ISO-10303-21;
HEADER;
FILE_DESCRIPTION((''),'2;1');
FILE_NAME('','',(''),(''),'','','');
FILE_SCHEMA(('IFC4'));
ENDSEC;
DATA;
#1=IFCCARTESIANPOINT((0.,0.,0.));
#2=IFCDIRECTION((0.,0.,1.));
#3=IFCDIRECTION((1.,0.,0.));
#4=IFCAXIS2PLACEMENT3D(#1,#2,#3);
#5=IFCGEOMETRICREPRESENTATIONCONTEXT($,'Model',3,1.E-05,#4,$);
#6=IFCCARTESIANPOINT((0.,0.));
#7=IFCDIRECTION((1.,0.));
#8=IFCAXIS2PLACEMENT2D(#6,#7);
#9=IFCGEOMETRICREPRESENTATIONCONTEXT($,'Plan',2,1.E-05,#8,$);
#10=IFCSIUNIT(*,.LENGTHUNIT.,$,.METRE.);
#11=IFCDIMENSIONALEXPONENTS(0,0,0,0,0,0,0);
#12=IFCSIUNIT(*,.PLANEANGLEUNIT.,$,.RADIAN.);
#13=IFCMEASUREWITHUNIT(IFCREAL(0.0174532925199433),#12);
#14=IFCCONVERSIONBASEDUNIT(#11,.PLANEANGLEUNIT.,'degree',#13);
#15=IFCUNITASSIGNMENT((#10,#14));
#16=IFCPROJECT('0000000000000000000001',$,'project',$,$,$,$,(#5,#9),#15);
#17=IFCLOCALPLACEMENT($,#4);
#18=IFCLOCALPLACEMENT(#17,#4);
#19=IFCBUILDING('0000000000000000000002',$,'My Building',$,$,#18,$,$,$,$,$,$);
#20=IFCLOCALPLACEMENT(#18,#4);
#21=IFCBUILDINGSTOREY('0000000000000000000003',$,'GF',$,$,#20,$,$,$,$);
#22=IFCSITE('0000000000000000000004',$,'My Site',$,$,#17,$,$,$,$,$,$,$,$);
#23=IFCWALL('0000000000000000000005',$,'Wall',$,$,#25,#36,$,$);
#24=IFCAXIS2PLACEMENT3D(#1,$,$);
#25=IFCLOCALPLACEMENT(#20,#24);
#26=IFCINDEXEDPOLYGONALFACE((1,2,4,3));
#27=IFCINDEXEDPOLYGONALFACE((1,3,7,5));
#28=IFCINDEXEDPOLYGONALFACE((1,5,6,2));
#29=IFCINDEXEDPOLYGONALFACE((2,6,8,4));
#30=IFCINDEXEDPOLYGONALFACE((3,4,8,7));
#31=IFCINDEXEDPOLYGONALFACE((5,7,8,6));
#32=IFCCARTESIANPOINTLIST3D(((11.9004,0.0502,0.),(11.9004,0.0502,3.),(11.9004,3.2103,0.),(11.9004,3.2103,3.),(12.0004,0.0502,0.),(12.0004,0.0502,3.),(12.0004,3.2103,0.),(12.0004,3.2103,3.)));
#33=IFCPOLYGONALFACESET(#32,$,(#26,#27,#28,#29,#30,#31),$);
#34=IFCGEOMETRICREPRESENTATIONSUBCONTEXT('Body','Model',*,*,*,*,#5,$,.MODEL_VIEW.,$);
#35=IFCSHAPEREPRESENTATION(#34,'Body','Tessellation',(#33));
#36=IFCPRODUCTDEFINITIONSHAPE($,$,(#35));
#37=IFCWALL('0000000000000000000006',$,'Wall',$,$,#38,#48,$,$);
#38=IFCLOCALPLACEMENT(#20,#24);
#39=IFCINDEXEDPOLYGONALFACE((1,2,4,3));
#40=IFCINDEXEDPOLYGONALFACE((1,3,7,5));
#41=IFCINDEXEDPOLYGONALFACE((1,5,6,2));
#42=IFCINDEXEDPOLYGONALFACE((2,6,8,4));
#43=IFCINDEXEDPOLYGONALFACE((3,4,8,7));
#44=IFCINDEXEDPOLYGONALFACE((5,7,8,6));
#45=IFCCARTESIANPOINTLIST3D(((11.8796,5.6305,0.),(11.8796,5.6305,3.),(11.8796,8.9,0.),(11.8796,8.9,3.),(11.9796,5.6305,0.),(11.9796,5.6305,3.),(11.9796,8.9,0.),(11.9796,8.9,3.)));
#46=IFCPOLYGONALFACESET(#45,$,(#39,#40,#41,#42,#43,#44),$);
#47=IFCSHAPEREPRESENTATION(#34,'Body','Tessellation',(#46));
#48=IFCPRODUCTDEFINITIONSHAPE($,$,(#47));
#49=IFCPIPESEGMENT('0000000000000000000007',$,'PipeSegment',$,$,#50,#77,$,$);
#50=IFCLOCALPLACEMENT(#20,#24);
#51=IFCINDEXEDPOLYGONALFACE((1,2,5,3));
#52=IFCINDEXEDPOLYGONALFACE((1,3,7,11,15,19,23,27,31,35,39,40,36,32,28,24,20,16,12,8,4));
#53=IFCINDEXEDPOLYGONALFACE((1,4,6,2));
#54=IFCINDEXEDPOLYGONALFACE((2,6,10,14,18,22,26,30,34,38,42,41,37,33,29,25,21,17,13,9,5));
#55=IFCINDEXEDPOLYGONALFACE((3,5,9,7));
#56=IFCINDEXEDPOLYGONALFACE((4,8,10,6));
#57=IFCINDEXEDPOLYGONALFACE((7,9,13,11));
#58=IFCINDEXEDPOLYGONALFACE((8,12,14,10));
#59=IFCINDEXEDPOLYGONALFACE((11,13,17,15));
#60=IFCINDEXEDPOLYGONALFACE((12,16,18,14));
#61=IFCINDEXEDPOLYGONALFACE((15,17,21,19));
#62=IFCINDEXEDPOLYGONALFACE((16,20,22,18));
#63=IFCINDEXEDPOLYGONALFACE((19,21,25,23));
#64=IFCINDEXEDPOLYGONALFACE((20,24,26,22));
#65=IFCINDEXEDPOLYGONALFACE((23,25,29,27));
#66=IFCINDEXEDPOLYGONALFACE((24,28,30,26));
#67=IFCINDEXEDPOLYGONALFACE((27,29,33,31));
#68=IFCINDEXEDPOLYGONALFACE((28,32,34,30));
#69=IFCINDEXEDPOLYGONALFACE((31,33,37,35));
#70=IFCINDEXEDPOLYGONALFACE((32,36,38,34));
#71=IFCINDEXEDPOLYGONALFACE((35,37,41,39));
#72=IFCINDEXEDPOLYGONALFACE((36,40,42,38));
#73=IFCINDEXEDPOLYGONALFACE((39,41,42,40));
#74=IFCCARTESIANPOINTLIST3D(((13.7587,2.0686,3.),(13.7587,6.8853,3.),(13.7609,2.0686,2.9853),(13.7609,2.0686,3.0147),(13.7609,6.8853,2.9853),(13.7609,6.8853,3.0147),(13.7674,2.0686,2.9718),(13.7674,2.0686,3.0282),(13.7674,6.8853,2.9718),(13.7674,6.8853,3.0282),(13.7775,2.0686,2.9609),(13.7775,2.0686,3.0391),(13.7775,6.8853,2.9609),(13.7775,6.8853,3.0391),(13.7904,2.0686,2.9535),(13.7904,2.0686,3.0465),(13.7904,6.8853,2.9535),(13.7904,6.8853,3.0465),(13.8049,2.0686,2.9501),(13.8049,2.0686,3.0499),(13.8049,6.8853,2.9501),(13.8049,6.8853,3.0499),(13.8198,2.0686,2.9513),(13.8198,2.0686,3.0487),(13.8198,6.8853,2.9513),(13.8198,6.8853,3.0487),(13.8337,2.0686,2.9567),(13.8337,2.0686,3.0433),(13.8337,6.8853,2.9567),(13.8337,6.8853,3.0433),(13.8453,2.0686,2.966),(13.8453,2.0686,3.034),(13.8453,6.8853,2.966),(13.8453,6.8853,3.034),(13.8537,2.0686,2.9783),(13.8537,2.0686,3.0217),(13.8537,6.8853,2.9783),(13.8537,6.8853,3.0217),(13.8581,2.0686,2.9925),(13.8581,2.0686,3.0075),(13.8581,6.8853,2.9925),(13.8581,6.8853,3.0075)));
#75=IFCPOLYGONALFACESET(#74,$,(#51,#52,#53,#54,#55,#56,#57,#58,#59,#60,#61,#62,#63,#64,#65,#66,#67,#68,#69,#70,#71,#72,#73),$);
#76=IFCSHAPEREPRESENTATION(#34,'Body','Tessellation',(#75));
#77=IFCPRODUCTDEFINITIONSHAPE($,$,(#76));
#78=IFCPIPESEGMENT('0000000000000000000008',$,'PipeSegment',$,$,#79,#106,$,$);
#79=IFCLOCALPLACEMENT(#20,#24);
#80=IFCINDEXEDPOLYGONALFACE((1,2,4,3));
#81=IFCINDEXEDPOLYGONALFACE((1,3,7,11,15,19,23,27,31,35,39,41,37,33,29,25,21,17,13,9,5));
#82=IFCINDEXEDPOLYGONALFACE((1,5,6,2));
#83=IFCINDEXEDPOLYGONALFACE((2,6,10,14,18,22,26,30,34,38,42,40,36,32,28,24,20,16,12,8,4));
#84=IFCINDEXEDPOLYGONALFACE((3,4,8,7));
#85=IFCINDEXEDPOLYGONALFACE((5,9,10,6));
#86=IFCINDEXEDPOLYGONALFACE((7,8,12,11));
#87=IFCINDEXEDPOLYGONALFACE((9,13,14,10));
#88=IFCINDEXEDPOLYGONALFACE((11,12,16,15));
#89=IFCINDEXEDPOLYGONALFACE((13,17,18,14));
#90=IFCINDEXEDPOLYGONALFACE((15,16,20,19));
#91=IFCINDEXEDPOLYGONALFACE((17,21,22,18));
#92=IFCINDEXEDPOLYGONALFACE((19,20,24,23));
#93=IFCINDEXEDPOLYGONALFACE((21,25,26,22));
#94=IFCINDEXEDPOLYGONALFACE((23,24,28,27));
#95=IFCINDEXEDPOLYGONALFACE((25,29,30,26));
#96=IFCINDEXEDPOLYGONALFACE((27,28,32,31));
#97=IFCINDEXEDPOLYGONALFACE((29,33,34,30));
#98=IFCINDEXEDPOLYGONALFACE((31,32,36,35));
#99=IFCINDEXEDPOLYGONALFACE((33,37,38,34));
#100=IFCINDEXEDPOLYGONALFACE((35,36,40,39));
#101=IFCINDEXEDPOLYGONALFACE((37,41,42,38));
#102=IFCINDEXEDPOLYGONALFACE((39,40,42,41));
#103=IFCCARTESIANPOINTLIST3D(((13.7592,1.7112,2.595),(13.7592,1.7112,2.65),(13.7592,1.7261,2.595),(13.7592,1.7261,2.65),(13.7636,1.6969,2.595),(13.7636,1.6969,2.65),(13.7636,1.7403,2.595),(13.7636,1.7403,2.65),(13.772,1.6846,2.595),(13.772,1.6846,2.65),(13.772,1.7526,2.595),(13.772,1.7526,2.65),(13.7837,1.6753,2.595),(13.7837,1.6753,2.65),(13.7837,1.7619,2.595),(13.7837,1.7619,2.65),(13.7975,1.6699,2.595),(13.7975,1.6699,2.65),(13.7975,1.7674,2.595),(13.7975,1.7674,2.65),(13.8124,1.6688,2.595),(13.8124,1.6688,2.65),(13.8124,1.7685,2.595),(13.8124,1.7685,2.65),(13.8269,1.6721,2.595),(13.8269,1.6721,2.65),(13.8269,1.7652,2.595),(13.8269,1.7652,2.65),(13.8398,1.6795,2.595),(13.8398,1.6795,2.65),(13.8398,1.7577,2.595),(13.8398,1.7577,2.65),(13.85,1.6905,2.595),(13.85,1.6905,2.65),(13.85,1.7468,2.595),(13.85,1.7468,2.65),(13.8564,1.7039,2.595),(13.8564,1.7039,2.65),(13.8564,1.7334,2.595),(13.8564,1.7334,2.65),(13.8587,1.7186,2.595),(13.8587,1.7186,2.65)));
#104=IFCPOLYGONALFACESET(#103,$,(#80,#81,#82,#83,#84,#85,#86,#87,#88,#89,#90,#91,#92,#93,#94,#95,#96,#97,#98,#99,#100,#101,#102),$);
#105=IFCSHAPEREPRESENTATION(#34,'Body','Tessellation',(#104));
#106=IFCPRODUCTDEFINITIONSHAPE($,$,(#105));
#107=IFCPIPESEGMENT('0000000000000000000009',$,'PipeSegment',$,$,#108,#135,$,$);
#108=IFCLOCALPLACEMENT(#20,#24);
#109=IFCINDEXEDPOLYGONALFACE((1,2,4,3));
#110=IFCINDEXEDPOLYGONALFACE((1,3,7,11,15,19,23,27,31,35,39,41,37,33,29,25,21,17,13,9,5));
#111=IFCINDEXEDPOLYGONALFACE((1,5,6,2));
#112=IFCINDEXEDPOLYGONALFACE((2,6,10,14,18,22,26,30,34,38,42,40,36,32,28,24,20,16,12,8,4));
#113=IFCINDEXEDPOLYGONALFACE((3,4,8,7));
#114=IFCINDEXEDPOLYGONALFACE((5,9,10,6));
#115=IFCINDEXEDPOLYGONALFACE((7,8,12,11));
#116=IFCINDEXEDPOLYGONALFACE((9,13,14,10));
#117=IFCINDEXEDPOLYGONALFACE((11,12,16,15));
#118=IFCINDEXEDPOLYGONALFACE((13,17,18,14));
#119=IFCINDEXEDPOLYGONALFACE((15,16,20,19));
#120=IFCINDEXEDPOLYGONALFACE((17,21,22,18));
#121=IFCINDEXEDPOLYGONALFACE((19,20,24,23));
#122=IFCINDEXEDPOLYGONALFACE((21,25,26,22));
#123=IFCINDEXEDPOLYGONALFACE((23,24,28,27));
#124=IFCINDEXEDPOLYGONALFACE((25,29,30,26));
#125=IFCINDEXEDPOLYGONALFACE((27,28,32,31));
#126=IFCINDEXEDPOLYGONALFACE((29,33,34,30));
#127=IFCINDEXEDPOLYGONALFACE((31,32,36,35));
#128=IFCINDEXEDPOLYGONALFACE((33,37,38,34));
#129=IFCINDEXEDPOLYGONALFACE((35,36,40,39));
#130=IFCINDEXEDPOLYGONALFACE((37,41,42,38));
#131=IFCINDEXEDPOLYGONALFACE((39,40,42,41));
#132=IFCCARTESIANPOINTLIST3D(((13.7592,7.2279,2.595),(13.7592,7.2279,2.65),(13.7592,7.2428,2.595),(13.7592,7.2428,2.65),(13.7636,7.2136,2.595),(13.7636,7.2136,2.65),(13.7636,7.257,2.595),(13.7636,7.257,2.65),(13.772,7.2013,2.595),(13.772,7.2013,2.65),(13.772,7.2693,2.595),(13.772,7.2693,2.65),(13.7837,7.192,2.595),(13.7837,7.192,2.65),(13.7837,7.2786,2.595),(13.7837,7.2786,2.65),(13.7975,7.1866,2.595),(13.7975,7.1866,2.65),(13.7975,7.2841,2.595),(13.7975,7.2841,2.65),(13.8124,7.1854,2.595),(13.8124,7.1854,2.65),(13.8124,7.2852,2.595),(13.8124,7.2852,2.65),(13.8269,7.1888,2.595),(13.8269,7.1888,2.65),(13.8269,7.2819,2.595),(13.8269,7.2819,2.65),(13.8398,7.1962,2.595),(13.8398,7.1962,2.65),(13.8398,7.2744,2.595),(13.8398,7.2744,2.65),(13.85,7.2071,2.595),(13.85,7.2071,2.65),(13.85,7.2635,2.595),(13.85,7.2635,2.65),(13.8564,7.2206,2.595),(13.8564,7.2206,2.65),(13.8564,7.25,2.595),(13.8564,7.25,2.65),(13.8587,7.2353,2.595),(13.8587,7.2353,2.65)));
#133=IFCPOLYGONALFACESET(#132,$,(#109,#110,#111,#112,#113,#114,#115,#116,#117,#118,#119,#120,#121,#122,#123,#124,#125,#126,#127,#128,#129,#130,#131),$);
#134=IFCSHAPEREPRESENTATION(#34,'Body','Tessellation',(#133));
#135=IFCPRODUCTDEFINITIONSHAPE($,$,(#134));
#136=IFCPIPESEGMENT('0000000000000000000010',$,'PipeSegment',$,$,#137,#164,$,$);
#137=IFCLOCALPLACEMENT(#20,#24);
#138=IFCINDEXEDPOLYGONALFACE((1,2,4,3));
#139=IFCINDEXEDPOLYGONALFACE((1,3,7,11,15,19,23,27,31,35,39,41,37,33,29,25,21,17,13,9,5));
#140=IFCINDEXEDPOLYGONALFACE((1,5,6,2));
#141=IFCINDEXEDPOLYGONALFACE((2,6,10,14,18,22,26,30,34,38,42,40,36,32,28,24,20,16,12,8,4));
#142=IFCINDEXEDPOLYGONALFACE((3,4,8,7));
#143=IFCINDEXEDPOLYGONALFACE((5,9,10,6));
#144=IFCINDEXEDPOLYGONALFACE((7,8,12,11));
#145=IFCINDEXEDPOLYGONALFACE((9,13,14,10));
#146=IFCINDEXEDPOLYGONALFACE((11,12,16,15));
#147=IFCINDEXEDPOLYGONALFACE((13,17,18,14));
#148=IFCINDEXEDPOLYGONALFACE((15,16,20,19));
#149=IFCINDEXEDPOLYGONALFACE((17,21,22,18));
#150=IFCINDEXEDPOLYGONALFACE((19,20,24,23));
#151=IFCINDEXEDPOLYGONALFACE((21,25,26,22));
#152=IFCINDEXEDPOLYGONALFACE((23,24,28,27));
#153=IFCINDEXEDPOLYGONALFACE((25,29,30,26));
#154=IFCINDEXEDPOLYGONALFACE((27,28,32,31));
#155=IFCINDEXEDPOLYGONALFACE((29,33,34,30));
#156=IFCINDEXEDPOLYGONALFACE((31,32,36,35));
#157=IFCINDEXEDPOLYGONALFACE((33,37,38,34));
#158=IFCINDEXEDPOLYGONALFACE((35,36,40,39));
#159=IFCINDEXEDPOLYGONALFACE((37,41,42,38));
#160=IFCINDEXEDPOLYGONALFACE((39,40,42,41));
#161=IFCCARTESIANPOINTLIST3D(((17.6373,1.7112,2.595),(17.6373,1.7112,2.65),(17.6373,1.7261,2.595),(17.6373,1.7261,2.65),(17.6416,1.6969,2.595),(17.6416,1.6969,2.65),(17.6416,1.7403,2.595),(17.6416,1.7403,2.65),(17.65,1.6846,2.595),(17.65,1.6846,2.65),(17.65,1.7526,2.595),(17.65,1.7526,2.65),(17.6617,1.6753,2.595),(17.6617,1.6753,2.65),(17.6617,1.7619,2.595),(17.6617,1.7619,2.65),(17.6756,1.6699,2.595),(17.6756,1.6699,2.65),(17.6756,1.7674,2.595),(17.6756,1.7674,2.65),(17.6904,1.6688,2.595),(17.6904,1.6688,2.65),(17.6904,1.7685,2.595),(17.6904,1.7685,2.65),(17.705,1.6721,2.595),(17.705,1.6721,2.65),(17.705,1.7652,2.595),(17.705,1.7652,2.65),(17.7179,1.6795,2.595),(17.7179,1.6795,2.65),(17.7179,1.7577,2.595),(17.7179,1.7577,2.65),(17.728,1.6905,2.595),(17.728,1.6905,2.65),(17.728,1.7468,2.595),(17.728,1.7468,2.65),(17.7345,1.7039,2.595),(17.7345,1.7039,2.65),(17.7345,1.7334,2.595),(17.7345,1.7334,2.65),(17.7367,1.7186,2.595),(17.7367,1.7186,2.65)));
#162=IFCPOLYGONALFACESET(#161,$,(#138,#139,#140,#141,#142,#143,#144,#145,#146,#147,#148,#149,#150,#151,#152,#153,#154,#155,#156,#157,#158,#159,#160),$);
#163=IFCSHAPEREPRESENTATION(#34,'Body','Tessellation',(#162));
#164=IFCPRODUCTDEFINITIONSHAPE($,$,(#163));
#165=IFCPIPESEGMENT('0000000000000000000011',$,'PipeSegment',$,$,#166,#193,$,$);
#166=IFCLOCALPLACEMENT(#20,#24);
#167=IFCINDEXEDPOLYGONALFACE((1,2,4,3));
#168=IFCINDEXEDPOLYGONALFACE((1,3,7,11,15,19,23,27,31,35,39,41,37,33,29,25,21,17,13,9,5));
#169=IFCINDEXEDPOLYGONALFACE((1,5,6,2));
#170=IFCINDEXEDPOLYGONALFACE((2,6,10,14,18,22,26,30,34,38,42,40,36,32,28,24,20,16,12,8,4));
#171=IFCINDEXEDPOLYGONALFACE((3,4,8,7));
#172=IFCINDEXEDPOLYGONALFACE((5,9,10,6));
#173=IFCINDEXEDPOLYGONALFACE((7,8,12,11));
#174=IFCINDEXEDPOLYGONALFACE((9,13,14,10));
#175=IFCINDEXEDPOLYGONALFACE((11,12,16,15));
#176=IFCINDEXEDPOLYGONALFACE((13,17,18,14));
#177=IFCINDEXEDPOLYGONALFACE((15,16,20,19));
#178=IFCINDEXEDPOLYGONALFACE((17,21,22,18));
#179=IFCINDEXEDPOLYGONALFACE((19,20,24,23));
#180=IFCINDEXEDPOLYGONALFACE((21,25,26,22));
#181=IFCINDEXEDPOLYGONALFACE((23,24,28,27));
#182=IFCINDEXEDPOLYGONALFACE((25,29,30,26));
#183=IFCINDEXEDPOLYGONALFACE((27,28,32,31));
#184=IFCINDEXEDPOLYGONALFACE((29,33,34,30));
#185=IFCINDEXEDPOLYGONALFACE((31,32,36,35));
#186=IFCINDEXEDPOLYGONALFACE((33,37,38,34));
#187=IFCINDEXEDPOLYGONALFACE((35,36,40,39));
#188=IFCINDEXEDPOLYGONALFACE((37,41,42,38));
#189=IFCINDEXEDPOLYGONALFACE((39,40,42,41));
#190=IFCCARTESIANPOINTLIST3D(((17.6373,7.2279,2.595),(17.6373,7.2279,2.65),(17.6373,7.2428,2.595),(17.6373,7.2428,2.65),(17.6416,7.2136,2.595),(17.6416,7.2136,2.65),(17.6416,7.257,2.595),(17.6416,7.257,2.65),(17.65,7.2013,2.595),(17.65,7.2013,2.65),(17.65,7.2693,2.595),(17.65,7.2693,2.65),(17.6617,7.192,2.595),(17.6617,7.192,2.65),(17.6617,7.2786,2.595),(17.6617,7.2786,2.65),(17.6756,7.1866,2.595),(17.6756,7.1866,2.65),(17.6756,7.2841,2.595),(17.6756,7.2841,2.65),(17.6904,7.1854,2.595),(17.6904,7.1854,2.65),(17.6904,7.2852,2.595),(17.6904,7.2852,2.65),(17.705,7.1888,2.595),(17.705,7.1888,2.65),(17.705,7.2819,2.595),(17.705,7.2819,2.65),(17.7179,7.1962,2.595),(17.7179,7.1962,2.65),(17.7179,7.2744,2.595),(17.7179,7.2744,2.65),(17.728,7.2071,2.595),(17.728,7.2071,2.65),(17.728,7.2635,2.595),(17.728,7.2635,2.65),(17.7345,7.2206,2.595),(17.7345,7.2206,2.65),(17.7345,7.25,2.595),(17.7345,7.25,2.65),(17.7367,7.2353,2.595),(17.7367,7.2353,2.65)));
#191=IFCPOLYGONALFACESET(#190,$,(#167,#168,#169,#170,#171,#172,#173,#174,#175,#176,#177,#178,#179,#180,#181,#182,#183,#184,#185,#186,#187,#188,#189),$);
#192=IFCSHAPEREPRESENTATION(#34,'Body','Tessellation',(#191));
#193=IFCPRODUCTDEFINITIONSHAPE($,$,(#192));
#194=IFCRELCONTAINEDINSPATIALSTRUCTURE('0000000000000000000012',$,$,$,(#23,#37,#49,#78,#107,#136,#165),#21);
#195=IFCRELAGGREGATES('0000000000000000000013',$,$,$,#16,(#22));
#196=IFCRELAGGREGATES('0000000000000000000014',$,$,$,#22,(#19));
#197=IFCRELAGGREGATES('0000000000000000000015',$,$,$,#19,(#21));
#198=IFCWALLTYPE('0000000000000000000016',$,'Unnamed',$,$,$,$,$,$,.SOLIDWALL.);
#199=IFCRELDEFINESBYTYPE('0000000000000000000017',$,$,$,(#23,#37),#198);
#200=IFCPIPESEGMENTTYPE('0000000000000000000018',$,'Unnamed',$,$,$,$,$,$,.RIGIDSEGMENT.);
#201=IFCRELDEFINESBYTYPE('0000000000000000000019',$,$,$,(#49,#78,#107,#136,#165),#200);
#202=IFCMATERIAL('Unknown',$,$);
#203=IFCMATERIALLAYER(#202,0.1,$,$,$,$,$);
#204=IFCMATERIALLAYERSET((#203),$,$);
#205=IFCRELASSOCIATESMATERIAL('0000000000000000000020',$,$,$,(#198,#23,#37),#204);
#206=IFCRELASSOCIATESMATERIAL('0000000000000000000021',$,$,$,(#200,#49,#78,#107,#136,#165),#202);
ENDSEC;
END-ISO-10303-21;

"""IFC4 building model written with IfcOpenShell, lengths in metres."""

from ifc_helpers import new_model, entity, si_unit, converted_unit, frame, origin_with_axes, origin_2d_with_axis, place, context, subcontext, project, spatial, line, indexed_curve, circle, outline, extrude, material, layer, layer_set, layer_usage, material_profile, profile_set, profile_usage, type_object, element, save


model = new_model("IFC4")

# Units and contexts
model_context = context("Model", 3, precision=1e-05, world=origin_with_axes())
plan_context = context("Plan", 2, precision=1e-05, world=origin_2d_with_axis())
body_context_1 = subcontext(model_context, "Body", "Model", "MODEL_VIEW")
ifc_project = project(units=[si_unit("LENGTHUNIT", "METRE"), converted_unit("PLANEANGLEUNIT", "degree", entity("IfcReal", 0.0174532925199433), si_unit("PLANEANGLEUNIT", "RADIAN"), dimensions=[0, 0, 0, 0, 0, 0, 0])], contexts=[model_context, plan_context])

# Site, building, storey
site_placement = place(None, origin_with_axes())
site = spatial("IfcSite", under=ifc_project, at=site_placement, Name="My Site")
building_placement = place(site_placement, origin_with_axes())
building = spatial("IfcBuilding", under=site, at=building_placement, Name="My Building")
storey_placement = place(building_placement, origin_with_axes())
storey = spatial("IfcBuildingStorey", under=building, at=storey_placement, Name="GF")

# Shared definitions
ifc_material = material(Name="Unknown")
ifc_layer = layer(ifc_material, 0.1)
ifc_layer_set = layer_set([ifc_layer])
wall_type = type_object("IfcWallType", Name="Unnamed", PredefinedType="SOLIDWALL", material=ifc_layer_set)

# Walls
ifc_layer_usage_1 = layer_usage(ifc_layer_set, "AXIS2", "POSITIVE", 0.0)
wall_1_placement = place(storey_placement, frame((12.0004, 0.0502, 0.0), z_axis=(0.0, 0.0, 1.0), x_axis=(0.000013, 1.0, 0.0)))
element("IfcWall", 1, at=wall_1_placement, inside=storey, type_object=wall_type, material=ifc_layer_usage_1, Name="Wall", context=body_context_1, shape_type="SweptSolid", body=[
    extrude(outline(indexed_curve([(0.0, 0.0), (0.0, 0.1), (3.1602, 0.1), (3.1602, 0.0)], segments=[line(1, 2, 3, 4, 1)])), origin_with_axes(), (0.0, 0.0, 1.0), 3.0),
])
ifc_layer_usage_2 = layer_usage(ifc_layer_set, "AXIS2", "POSITIVE", 0.0)
wall_2_placement = place(storey_placement, frame((11.9796, 5.6305, 0.0), z_axis=(0.0, 0.0, 1.0), x_axis=(0.0, 1.0, 0.0)))
element("IfcWall", 2, at=wall_2_placement, inside=storey, type_object=wall_type, material=ifc_layer_usage_2, Name="Wall", context=body_context_1, shape_type="SweptSolid", body=[
    extrude(outline(indexed_curve([(0.0, 0.0), (0.0, 0.1), (3.2695, 0.1), (3.2695, 0.0)], segments=[line(1, 2, 3, 4, 1)])), origin_with_axes(), (0.0, 0.0, 1.0), 3.0),
])

# Pipe segments
ifc_material_profile = material_profile(ifc_material, circle(Radius=0.05))
ifc_profile_set = profile_set([ifc_material_profile])
ifc_profile_usage_1 = profile_usage(ifc_profile_set, cardinal=5)
pipe_segment_type = type_object("IfcPipeSegmentType", Name="Unnamed", PredefinedType="RIGIDSEGMENT", material=ifc_profile_set)
pipe_segment_1_placement = place(storey_placement, frame((13.8087, 6.8853, 3.0), z_axis=(0.0, -1.0, 0.0), x_axis=(-1.0, 0.0, 0.0)))
element("IfcPipeSegment", 3, at=pipe_segment_1_placement, inside=storey, type_object=pipe_segment_type, material=ifc_profile_usage_1, Name="PipeSegment", context=body_context_1, shape_type="SweptSolid", body=[
    extrude(circle(Radius=0.05), origin_with_axes(), (0.0, 0.0, 1.0), 4.8167),
])
ifc_profile_usage_2 = profile_usage(ifc_profile_set, cardinal=5)
pipe_segment_2_placement = place(storey_placement, frame((13.8087, 1.7186, 2.65), z_axis=(0.0, 0.0, -1.0), x_axis=(1.0, 0.0, 0.0)))
element("IfcPipeSegment", 4, at=pipe_segment_2_placement, inside=storey, type_object=pipe_segment_type, material=ifc_profile_usage_2, Name="PipeSegment", context=body_context_1, shape_type="SweptSolid", body=[
    extrude(circle(Radius=0.05), origin_with_axes(), (0.0, 0.0, 1.0), 0.055),
])
ifc_profile_usage_3 = profile_usage(ifc_profile_set, cardinal=5)
pipe_segment_3_placement = place(storey_placement, frame((13.8087, 7.2353, 2.65), z_axis=(0.0, 0.0, -1.0), x_axis=(1.0, 0.0, 0.0)))
element("IfcPipeSegment", 5, at=pipe_segment_3_placement, inside=storey, type_object=pipe_segment_type, material=ifc_profile_usage_3, Name="PipeSegment", context=body_context_1, shape_type="SweptSolid", body=[
    extrude(circle(Radius=0.05), origin_with_axes(), (0.0, 0.0, 1.0), 0.055),
])
ifc_profile_usage_4 = profile_usage(ifc_profile_set, cardinal=5)
pipe_segment_4_placement = place(storey_placement, frame((17.6867, 1.7186, 2.65), z_axis=(0.0, 0.0, -1.0), x_axis=(1.0, 0.0, 0.0)))
element("IfcPipeSegment", 6, at=pipe_segment_4_placement, inside=storey, type_object=pipe_segment_type, material=ifc_profile_usage_4, Name="PipeSegment", context=body_context_1, shape_type="SweptSolid", body=[
    extrude(circle(Radius=0.05), origin_with_axes(), (0.0, 0.0, 1.0), 0.055),
])
ifc_profile_usage_5 = profile_usage(ifc_profile_set, cardinal=5)
pipe_segment_5_placement = place(storey_placement, frame((17.6867, 7.2353, 2.65), z_axis=(0.0, 0.0, -1.0), x_axis=(1.0, 0.0, 0.0)))
element("IfcPipeSegment", 7, at=pipe_segment_5_placement, inside=storey, type_object=pipe_segment_type, material=ifc_profile_usage_5, Name="PipeSegment", context=body_context_1, shape_type="SweptSolid", body=[
    extrude(circle(Radius=0.05), origin_with_axes(), (0.0, 0.0, 1.0), 0.055),
])

save(model, "model.ifc")
